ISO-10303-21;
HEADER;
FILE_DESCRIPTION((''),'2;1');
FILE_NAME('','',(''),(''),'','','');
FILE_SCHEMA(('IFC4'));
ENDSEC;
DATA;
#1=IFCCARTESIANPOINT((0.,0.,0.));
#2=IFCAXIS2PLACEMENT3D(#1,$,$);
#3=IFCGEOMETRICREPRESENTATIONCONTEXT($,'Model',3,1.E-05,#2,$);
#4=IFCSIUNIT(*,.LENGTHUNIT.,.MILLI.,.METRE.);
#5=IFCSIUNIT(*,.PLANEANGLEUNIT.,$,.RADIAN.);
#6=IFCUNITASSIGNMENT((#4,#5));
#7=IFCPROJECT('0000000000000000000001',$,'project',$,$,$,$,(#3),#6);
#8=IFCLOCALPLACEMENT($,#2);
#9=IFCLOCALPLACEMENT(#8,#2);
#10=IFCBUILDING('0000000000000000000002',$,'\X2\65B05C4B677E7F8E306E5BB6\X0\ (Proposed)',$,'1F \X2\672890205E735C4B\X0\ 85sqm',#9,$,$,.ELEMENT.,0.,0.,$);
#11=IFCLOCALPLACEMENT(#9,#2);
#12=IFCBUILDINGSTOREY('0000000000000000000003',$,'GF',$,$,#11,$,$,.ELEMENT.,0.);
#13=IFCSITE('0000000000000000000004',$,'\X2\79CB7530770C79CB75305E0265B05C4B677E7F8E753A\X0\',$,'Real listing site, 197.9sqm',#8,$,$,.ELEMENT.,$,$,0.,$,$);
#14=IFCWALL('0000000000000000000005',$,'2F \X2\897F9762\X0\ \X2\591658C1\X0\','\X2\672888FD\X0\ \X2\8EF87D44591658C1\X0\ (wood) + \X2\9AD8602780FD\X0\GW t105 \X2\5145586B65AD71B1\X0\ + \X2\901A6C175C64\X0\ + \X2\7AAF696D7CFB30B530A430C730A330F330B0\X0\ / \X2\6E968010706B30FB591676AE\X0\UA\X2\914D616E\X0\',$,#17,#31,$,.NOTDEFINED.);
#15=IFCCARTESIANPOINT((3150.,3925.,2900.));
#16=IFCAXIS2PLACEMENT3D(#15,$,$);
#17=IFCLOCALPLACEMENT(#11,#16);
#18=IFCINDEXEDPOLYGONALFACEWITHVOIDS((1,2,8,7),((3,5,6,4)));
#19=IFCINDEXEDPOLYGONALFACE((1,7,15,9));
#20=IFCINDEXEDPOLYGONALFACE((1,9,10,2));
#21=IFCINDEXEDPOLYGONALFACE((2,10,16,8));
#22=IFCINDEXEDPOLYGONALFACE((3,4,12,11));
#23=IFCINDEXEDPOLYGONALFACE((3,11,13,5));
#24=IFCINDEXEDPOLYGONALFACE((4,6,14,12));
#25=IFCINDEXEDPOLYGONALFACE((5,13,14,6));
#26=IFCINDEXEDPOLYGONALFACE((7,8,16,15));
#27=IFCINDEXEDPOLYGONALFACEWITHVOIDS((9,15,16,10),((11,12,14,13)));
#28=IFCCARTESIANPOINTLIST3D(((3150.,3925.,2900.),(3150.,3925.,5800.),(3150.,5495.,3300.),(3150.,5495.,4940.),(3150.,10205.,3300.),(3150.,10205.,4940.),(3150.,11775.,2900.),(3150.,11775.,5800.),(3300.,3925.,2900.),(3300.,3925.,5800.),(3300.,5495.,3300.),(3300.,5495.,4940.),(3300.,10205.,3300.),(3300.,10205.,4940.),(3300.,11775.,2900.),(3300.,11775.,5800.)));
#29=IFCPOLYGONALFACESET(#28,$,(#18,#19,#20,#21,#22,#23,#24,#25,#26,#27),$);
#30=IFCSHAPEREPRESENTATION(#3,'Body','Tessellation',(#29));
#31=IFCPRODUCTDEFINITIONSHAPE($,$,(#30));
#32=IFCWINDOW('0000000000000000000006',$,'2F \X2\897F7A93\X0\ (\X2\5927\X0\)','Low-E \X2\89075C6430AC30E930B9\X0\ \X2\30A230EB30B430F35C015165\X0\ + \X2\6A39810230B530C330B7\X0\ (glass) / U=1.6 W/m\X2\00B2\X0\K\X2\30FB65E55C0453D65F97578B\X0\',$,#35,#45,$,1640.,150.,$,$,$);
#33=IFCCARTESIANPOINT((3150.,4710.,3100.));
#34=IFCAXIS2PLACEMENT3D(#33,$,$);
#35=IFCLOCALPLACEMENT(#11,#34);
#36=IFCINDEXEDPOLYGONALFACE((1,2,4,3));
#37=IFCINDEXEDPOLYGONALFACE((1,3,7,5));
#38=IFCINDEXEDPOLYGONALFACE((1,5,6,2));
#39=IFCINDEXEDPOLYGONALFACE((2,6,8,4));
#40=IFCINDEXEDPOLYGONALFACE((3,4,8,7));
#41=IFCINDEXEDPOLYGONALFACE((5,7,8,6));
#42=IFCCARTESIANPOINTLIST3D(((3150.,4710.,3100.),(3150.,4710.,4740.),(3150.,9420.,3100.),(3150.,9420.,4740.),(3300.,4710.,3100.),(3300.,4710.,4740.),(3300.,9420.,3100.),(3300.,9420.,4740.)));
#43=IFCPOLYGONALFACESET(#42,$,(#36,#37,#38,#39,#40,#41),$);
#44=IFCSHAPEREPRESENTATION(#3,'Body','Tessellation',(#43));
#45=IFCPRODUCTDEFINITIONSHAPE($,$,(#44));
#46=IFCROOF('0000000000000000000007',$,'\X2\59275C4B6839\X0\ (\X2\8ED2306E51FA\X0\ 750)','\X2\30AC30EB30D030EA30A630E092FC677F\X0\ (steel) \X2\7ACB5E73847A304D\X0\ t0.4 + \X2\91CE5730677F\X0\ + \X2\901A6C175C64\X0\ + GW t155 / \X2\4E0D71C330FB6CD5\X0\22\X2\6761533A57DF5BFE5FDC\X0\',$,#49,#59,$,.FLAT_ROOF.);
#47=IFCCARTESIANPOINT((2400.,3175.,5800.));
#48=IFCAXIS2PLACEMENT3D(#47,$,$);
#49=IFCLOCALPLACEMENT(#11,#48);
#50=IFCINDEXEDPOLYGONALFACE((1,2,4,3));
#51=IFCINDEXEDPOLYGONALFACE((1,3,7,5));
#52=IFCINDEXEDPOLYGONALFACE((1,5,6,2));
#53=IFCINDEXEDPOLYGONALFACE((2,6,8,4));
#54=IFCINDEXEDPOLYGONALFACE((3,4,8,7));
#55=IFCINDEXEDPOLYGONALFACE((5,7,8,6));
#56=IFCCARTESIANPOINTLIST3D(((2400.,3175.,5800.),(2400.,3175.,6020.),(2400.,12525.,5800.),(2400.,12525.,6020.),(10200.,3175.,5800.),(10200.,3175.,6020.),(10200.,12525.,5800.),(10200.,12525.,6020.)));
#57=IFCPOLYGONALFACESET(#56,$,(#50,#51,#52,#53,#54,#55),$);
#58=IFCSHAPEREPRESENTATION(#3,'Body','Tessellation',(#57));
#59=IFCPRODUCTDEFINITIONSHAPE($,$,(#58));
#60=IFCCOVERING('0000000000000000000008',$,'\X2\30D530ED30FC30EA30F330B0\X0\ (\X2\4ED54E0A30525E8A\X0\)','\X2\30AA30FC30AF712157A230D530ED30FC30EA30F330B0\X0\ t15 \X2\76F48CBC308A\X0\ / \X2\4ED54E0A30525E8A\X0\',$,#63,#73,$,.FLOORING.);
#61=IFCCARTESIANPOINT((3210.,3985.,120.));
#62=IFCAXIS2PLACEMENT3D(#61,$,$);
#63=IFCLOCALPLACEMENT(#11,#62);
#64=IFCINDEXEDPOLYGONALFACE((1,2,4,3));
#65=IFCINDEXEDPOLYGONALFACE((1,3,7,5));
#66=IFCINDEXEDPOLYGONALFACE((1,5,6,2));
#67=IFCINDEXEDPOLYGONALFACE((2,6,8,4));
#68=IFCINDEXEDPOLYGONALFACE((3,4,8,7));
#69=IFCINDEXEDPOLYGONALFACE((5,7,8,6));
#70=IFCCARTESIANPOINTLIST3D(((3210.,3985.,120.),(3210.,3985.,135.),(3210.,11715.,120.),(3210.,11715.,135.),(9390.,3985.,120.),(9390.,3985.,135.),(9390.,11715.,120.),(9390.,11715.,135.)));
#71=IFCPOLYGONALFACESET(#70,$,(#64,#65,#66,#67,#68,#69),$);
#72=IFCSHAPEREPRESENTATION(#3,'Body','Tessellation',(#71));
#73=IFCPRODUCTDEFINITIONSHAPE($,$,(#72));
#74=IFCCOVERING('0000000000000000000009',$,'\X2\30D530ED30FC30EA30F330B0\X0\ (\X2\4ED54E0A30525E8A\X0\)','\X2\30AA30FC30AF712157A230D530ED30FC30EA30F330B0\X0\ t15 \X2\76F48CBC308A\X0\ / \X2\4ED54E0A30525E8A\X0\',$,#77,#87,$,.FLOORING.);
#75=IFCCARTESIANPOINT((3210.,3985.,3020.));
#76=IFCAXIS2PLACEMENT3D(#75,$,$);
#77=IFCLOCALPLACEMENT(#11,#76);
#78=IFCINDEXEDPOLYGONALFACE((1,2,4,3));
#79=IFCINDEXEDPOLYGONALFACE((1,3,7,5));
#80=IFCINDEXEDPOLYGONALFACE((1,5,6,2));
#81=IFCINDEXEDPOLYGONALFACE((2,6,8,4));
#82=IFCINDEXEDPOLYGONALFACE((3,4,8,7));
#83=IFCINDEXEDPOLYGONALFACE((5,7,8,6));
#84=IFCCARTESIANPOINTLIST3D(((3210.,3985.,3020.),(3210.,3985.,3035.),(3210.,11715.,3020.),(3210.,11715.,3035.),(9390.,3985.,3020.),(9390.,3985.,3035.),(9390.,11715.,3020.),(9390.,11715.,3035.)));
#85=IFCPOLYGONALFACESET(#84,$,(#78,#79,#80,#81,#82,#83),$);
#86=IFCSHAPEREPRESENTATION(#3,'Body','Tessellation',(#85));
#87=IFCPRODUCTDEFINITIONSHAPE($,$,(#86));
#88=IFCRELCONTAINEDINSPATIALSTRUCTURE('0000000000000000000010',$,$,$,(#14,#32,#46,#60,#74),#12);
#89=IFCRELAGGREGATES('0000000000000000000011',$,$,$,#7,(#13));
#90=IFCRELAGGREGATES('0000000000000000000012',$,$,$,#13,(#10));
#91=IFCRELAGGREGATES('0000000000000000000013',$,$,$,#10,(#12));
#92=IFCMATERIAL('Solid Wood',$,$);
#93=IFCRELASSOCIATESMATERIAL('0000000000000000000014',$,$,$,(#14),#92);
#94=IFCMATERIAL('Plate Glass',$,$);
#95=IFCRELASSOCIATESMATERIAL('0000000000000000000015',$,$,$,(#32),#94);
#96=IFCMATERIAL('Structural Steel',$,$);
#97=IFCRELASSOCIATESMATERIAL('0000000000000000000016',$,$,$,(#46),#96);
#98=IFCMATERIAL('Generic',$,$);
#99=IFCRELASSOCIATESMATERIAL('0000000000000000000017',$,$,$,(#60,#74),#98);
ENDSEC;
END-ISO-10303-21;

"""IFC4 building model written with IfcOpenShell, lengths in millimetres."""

from ifc_helpers import new_model, si_unit, frame, frame_2d, origin, place, context, project, spatial, rectangle, extrude, material, element, fill, save


model = new_model("IFC4")

# Units and contexts
model_context = context("Model", 3, precision=1e-05, world=origin())
ifc_project = project(units=[si_unit("LENGTHUNIT", "METRE", prefix="MILLI"), si_unit("PLANEANGLEUNIT", "RADIAN")], contexts=[model_context])

# Site, building, storey
site_placement = place(None, origin())
site = spatial("IfcSite", under=ifc_project, at=site_placement, Name="秋田県秋田市新屋松美町", ObjectType="Real listing site, 197.9sqm", CompositionType="ELEMENT", RefElevation=0.0)
building_placement = place(site_placement, origin())
building = spatial("IfcBuilding", under=site, at=building_placement, Name="新屋松美の家 (Proposed)", ObjectType="1F 木造平屋 85sqm", CompositionType="ELEMENT", ElevationOfRefHeight=0.0, ElevationOfTerrain=0.0)
storey_placement = place(building_placement, origin())
storey = spatial("IfcBuildingStorey", under=building, at=storey_placement, Name="GF", CompositionType="ELEMENT", Elevation=0.0)

# Shared definitions
ifc_material_1 = material(Name="Solid Wood")
ifc_material_2 = material(Name="Generic")

# Shared definitions
ifc_material_3 = material(Name="Plate Glass")

# Wall, opening, window
wall_1_placement = place(storey_placement, frame((3150.0, 3925.0, 2900.0)))
wall_1 = element("IfcWall", 1, at=wall_1_placement, inside=storey, material=ifc_material_1, Name="2F 西面 外壁", Description="木製 軸組外壁 (wood) + 高性能GW t105 充填断熱 + 通気層 + 窯業系サイディング / 準耐火・外皮UA配慮", PredefinedType="NOTDEFINED", context=model_context, shape_type="SweptSolid", body=[
    extrude(rectangle(XDim=150.0, YDim=7850.0, at=frame_2d((75.0, 3925.0))), frame((3150.0, 3925.0, 2900.0)), (0.0, 0.0, 1.0), 2900.0),
])
opening_1_placement = place(storey_placement, frame((3150.0, 4710.0, 3100.0)))
opening_1 = element("IfcOpeningElement", 2, at=opening_1_placement, cuts=wall_1, PredefinedType="NOTDEFINED", context=model_context, shape_type="SweptSolid", body=[
    extrude(rectangle(XDim=150.0, YDim=4710.0, at=frame_2d((75.0, 2355.0))), frame((3150.0, 4710.0, 3100.0)), (0.0, 0.0, 1.0), 1640.0),
])
window_1_placement = place(storey_placement, frame((3150.0, 4710.0, 3100.0)))
window_1 = element("IfcWindow", 3, at=window_1_placement, inside=storey, material=ifc_material_3, Name="2F 西窓 (大)", Description="Low-E 複層ガラス アルゴン封入 + 樹脂サッシ (glass) / U=1.6 W/m²K・日射取得型", OverallHeight=1640.0, OverallWidth=150.0, context=model_context, shape_type="SweptSolid", body=[
    extrude(rectangle(XDim=150.0, YDim=4710.0, at=frame_2d((75.0, 2355.0))), frame((3150.0, 4710.0, 3100.0)), (0.0, 0.0, 1.0), 1640.0),
])
fill(opening_1, window_1)

# Roof
ifc_material_4 = material(Name="Structural Steel")
roof_placement = place(storey_placement, frame((2400.0, 3175.0, 5800.0)))
element("IfcRoof", 4, at=roof_placement, inside=storey, material=ifc_material_4, Name="大屋根 (軒の出 750)", Description="ガルバリウム鋼板 (steel) 立平葺き t0.4 + 野地板 + 通気層 + GW t155 / 不燃・法22条区域対応", PredefinedType="FLAT_ROOF", context=model_context, shape_type="SweptSolid", body=[
    extrude(rectangle(XDim=7800.0, YDim=9350.0, at=frame_2d((3900.0, 4675.0))), frame((2400.0, 3175.0, 5800.0)), (0.0, 0.0, 1.0), 220.0),
])

# Coverings
covering_1_placement = place(storey_placement, frame((3210.0, 3985.0, 120.0)))
element("IfcCovering", 5, at=covering_1_placement, inside=storey, material=ifc_material_2, Name="フローリング (仕上げ床)", Description="オーク無垢フローリング t15 直貼り / 仕上げ床", PredefinedType="FLOORING", context=model_context, shape_type="SweptSolid", body=[
    extrude(rectangle(XDim=6180.0, YDim=7730.0, at=frame_2d((3090.0, 3865.0))), frame((3210.0, 3985.0, 120.0)), (0.0, 0.0, 1.0), 15.0),
])
covering_2_placement = place(storey_placement, frame((3210.0, 3985.0, 3020.0)))
element("IfcCovering", 6, at=covering_2_placement, inside=storey, material=ifc_material_2, Name="フローリング (仕上げ床)", Description="オーク無垢フローリング t15 直貼り / 仕上げ床", PredefinedType="FLOORING", context=model_context, shape_type="SweptSolid", body=[
    extrude(rectangle(XDim=6180.0, YDim=7730.0, at=frame_2d((3090.0, 3865.0))), frame((3210.0, 3985.0, 3020.0)), (0.0, 0.0, 1.0), 15.0),
])

save(model, "model.ifc")
